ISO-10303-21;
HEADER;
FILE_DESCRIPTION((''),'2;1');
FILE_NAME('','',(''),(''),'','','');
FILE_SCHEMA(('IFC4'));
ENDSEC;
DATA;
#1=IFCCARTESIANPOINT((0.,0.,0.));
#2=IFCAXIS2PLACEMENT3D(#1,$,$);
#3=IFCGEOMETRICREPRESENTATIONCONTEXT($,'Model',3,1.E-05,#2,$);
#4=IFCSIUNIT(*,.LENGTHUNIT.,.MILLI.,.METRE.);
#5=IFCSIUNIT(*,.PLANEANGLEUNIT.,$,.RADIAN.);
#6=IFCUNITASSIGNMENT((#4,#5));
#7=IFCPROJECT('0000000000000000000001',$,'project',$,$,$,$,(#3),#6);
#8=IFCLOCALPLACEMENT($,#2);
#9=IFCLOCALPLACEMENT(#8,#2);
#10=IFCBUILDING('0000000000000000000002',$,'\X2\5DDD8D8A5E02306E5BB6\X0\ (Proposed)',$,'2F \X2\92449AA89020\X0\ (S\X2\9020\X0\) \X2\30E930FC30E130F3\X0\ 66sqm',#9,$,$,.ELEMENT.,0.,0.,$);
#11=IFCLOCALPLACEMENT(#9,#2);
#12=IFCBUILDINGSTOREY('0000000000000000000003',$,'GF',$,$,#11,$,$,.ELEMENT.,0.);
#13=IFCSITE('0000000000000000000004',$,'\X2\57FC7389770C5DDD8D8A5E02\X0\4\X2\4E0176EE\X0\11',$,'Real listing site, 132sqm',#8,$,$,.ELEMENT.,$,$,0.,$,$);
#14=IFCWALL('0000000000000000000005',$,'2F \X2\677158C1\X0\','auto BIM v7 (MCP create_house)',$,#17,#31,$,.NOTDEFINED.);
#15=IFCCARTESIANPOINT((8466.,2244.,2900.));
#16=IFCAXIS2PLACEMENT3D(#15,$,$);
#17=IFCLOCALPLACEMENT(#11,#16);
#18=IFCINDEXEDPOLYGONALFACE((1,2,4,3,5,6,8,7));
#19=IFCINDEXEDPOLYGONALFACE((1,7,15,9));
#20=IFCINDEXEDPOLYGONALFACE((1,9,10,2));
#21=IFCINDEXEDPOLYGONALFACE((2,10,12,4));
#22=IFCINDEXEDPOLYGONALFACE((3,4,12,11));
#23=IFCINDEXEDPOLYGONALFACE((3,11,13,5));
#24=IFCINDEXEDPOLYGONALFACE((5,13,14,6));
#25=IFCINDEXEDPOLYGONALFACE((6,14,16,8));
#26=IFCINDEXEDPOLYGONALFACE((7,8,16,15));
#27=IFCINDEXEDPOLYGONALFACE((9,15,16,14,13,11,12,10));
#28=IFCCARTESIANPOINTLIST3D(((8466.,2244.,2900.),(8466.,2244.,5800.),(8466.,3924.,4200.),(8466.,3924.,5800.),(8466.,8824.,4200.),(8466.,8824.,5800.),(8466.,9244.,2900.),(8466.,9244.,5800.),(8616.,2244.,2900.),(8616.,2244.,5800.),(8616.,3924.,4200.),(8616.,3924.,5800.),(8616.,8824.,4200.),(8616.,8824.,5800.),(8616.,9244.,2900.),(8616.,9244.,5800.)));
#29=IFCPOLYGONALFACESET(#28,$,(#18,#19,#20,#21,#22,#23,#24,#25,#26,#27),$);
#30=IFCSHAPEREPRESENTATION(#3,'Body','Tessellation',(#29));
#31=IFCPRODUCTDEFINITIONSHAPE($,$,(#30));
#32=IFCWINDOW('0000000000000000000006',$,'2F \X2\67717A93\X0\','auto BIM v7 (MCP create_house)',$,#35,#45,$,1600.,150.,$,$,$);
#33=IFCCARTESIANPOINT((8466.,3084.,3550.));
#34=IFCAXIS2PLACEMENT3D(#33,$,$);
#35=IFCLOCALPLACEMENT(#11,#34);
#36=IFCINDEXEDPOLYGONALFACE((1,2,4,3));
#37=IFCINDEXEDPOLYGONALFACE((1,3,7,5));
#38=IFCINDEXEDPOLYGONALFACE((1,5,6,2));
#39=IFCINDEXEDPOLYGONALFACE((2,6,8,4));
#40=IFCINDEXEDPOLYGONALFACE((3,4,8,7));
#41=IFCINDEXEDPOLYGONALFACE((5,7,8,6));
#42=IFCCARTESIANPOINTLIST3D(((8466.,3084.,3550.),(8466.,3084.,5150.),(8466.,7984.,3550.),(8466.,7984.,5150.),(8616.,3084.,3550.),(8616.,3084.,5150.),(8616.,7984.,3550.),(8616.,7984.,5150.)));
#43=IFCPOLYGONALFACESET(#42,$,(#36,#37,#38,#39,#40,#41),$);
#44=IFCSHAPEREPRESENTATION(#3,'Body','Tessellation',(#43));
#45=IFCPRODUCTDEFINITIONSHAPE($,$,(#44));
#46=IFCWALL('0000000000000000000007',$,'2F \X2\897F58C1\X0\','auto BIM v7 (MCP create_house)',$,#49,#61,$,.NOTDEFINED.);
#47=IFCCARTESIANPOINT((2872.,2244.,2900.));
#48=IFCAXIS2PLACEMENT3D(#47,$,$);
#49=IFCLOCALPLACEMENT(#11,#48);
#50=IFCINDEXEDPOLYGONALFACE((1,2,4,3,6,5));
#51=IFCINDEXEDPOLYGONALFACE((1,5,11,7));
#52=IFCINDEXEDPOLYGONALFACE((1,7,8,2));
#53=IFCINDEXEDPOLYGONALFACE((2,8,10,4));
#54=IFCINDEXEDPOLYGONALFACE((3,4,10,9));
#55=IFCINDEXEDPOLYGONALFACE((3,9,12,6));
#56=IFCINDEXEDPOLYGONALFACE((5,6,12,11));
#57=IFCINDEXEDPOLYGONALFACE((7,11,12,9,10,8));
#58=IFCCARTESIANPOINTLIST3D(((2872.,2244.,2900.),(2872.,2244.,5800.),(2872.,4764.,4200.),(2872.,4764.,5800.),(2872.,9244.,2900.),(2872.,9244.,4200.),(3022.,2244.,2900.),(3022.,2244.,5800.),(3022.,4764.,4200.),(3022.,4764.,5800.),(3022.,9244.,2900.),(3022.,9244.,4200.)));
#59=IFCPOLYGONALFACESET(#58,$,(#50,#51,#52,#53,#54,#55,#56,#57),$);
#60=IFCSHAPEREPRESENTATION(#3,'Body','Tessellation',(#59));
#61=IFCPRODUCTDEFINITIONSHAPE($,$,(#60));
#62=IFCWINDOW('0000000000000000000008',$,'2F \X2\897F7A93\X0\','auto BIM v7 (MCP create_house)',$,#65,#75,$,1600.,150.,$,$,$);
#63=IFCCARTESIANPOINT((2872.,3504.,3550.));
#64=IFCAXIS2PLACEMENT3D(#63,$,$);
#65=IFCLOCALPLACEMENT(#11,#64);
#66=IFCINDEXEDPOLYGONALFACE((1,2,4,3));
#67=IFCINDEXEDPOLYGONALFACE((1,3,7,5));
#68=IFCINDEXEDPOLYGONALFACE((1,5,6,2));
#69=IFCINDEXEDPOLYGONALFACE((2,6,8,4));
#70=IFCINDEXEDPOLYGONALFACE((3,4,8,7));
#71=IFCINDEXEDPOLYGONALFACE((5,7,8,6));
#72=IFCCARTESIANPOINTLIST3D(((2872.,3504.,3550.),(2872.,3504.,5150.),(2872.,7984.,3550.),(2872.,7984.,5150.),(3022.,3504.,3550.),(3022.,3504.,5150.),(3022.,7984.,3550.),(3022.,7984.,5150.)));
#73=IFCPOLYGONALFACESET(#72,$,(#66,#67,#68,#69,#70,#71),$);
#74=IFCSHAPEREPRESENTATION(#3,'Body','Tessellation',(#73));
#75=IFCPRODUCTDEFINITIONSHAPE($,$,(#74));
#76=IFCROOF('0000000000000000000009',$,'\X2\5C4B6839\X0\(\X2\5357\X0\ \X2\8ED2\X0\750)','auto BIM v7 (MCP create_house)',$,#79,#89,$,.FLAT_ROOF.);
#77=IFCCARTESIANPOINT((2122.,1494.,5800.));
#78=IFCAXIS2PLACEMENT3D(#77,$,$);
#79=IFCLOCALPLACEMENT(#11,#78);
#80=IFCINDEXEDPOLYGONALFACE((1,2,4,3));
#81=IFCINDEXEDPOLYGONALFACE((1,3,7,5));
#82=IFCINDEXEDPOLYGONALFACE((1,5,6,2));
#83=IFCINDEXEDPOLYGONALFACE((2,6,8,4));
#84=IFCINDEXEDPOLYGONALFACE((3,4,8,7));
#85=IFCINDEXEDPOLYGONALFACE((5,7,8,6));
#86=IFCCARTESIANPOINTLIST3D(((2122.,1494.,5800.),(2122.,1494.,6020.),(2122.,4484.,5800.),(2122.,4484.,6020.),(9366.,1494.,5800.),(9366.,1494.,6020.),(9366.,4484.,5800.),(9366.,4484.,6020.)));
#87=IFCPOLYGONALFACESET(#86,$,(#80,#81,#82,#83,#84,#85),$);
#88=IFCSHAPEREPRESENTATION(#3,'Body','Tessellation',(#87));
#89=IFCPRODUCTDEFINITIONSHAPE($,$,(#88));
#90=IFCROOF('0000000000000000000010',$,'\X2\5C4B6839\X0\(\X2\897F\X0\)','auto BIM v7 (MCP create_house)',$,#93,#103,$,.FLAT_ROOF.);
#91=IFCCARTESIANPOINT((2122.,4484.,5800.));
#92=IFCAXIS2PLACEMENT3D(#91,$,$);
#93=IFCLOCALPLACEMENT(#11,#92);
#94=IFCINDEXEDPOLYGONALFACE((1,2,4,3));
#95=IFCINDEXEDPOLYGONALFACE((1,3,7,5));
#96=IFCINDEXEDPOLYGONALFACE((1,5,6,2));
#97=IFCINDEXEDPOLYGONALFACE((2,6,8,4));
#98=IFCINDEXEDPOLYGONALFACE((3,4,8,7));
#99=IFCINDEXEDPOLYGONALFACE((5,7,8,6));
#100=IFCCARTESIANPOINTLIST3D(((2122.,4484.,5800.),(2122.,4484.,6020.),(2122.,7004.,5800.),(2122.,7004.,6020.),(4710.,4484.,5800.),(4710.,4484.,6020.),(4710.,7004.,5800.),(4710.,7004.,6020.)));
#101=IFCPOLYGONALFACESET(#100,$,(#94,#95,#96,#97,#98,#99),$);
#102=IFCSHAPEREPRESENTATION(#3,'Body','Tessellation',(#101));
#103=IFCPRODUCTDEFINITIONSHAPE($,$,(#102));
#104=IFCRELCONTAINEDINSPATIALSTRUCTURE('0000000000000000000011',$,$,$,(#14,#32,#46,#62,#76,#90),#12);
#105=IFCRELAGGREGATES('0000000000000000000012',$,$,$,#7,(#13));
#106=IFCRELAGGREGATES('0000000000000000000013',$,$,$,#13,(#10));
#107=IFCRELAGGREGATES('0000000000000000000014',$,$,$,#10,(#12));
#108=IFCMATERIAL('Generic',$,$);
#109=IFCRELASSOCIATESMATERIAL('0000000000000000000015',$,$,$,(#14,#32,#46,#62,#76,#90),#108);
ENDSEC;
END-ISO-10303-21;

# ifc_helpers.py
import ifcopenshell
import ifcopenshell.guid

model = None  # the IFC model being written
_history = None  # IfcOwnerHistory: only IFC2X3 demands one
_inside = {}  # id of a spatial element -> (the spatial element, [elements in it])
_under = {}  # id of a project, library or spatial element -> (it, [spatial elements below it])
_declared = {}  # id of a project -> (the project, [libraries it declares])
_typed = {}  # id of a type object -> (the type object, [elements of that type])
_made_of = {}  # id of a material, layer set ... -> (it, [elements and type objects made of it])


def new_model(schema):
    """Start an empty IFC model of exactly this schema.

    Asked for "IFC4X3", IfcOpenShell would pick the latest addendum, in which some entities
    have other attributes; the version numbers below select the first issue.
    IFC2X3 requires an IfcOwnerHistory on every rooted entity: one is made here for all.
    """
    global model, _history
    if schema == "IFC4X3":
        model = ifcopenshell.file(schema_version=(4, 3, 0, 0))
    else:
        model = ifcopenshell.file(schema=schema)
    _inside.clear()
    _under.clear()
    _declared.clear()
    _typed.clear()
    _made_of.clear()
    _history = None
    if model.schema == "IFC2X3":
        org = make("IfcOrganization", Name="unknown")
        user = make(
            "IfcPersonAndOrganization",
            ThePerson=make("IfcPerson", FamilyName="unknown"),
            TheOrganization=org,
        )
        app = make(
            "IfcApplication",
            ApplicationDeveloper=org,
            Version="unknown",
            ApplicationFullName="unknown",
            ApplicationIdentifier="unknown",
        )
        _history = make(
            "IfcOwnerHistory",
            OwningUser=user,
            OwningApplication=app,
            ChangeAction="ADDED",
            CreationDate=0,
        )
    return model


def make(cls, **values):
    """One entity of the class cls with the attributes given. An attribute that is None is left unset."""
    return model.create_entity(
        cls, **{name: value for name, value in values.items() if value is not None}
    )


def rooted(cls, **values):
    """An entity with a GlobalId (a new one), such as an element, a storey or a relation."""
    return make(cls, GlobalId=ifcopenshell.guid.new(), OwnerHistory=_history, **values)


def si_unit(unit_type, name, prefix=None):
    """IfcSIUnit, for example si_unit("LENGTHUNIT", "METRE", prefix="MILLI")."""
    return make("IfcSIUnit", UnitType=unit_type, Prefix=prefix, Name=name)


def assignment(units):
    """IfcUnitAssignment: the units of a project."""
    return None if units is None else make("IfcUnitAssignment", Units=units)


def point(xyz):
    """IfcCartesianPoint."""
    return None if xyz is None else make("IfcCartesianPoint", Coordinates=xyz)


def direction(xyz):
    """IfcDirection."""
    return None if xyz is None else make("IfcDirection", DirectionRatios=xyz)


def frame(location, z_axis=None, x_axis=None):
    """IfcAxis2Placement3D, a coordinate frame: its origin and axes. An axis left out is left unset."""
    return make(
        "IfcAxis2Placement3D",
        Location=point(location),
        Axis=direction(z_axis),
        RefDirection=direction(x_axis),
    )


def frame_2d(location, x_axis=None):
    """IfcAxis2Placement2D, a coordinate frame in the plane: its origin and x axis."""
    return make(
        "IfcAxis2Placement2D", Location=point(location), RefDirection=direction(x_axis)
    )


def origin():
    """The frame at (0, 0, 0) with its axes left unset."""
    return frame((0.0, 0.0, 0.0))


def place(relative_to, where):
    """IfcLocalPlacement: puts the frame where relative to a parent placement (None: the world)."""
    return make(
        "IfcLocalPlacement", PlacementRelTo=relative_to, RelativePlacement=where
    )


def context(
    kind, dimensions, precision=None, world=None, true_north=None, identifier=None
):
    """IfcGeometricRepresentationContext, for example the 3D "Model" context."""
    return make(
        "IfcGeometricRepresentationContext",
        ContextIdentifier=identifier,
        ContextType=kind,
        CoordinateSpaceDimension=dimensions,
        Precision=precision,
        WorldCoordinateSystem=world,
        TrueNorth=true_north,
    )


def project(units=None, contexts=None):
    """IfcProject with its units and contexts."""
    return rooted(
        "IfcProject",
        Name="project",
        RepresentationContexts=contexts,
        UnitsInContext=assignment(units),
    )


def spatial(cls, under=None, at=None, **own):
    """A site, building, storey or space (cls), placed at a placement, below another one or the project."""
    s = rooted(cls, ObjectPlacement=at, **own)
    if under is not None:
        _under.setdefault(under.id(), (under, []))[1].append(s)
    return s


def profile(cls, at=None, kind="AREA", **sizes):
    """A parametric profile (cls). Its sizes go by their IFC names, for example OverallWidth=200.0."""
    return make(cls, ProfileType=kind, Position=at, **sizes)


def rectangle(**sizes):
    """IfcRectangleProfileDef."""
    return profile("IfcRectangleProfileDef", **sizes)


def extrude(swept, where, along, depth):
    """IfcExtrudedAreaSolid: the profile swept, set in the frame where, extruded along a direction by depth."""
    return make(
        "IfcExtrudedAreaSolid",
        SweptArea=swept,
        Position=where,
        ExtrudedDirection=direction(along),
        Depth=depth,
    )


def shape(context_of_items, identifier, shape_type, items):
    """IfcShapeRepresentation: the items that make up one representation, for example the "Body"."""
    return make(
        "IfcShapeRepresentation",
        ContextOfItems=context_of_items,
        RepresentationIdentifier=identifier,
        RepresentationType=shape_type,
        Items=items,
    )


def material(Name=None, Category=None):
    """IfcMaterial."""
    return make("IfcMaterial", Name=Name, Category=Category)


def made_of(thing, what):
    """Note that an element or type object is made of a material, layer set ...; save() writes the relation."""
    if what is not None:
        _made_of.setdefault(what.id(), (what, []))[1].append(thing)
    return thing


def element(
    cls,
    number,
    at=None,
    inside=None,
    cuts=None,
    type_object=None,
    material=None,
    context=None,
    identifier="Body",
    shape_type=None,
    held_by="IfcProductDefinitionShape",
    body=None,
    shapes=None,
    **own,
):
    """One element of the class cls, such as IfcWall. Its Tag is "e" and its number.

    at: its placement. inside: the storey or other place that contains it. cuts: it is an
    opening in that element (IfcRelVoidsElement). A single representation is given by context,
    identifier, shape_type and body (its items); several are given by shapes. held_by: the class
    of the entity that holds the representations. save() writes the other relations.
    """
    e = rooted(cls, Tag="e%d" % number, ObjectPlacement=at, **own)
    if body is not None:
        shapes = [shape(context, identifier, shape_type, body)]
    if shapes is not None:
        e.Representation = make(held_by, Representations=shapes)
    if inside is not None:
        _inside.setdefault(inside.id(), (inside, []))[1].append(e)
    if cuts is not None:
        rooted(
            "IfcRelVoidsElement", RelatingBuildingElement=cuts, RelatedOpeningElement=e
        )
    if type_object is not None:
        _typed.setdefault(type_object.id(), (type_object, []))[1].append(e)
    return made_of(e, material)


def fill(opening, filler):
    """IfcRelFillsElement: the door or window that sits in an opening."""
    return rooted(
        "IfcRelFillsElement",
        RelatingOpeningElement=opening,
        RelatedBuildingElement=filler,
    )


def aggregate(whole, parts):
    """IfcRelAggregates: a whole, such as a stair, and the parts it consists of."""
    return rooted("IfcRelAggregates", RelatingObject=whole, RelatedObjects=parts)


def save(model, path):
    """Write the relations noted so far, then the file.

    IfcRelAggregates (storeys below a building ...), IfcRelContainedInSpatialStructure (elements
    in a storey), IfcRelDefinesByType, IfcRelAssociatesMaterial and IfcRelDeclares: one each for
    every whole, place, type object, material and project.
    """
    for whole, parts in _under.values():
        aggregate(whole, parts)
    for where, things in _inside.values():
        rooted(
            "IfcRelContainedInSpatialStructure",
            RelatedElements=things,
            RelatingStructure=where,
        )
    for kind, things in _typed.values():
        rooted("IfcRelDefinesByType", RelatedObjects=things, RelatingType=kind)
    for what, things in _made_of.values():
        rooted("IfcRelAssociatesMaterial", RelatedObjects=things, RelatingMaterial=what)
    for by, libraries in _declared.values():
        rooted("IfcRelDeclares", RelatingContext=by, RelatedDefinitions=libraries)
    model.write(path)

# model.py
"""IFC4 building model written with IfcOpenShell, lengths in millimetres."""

from ifc_helpers import new_model, si_unit, frame, frame_2d, origin, place, context, project, spatial, rectangle, extrude, material, element, fill, save


model = new_model("IFC4")

# Units and contexts
model_context = context("Model", 3, precision=1e-05, world=origin())
ifc_project = project(units=[si_unit("LENGTHUNIT", "METRE", prefix="MILLI"), si_unit("PLANEANGLEUNIT", "RADIAN")], contexts=[model_context])

# Site, building, storey
site_placement = place(None, origin())
site = spatial("IfcSite", under=ifc_project, at=site_placement, Name="埼玉県川越市4丁目11", ObjectType="Real listing site, 132sqm", CompositionType="ELEMENT", RefElevation=0.0)
building_placement = place(site_placement, origin())
building = spatial("IfcBuilding", under=site, at=building_placement, Name="川越市の家 (Proposed)", ObjectType="2F 鉄骨造 (S造) ラーメン 66sqm", CompositionType="ELEMENT", ElevationOfRefHeight=0.0, ElevationOfTerrain=0.0)
storey_placement = place(building_placement, origin())
storey = spatial("IfcBuildingStorey", under=building, at=storey_placement, Name="GF", CompositionType="ELEMENT", Elevation=0.0)

# Shared definitions
ifc_material = material(Name="Generic")

# Walls, openings, windows
wall_1_placement = place(storey_placement, frame((8466.0, 2244.0, 2900.0)))
wall_1 = element("IfcWall", 1, at=wall_1_placement, inside=storey, material=ifc_material, Name="2F 東壁", Description="auto BIM v7 (MCP create_house)", PredefinedType="NOTDEFINED", context=model_context, shape_type="SweptSolid", body=[
    extrude(rectangle(XDim=150.0, YDim=7000.0, at=frame_2d((75.0, 3500.0))), frame((8466.0, 2244.0, 2900.0)), (0.0, 0.0, 1.0), 2900.0),
])
opening_1_placement = place(storey_placement, frame((8466.0, 3084.0, 3550.0)))
opening_1 = element("IfcOpeningElement", 2, at=opening_1_placement, cuts=wall_1, PredefinedType="NOTDEFINED", context=model_context, shape_type="SweptSolid", body=[
    extrude(rectangle(XDim=150.0, YDim=4900.0, at=frame_2d((75.0, 2450.0))), frame((8466.0, 3084.0, 3550.0)), (0.0, 0.0, 1.0), 1600.0),
])
window_1_placement = place(storey_placement, frame((8466.0, 3084.0, 3550.0)))
window_1 = element("IfcWindow", 3, at=window_1_placement, inside=storey, material=ifc_material, Name="2F 東窓", Description="auto BIM v7 (MCP create_house)", OverallHeight=1600.0, OverallWidth=150.0, context=model_context, shape_type="SweptSolid", body=[
    extrude(rectangle(XDim=150.0, YDim=4900.0, at=frame_2d((75.0, 2450.0))), frame((8466.0, 3084.0, 3550.0)), (0.0, 0.0, 1.0), 1600.0),
])
fill(opening_1, window_1)
wall_2_placement = place(storey_placement, frame((2872.0, 2244.0, 2900.0)))
wall_2 = element("IfcWall", 4, at=wall_2_placement, inside=storey, material=ifc_material, Name="2F 西壁", Description="auto BIM v7 (MCP create_house)", PredefinedType="NOTDEFINED", context=model_context, shape_type="SweptSolid", body=[
    extrude(rectangle(XDim=150.0, YDim=7000.0, at=frame_2d((75.0, 3500.0))), frame((2872.0, 2244.0, 2900.0)), (0.0, 0.0, 1.0), 2900.0),
])
opening_2_placement = place(storey_placement, frame((2872.0, 3504.0, 3550.0)))
opening_2 = element("IfcOpeningElement", 5, at=opening_2_placement, cuts=wall_2, PredefinedType="NOTDEFINED", context=model_context, shape_type="SweptSolid", body=[
    extrude(rectangle(XDim=150.0, YDim=4480.0, at=frame_2d((75.0, 2240.0))), frame((2872.0, 3504.0, 3550.0)), (0.0, 0.0, 1.0), 1600.0),
])
window_2_placement = place(storey_placement, frame((2872.0, 3504.0, 3550.0)))
window_2 = element("IfcWindow", 6, at=window_2_placement, inside=storey, material=ifc_material, Name="2F 西窓", Description="auto BIM v7 (MCP create_house)", OverallHeight=1600.0, OverallWidth=150.0, context=model_context, shape_type="SweptSolid", body=[
    extrude(rectangle(XDim=150.0, YDim=4480.0, at=frame_2d((75.0, 2240.0))), frame((2872.0, 3504.0, 3550.0)), (0.0, 0.0, 1.0), 1600.0),
])
fill(opening_2, window_2)

# Roofs
roof_1_placement = place(storey_placement, frame((2122.0, 1494.0, 5800.0)))
element("IfcRoof", 7, at=roof_1_placement, inside=storey, material=ifc_material, Name="屋根(南 軒750)", Description="auto BIM v7 (MCP create_house)", PredefinedType="FLAT_ROOF", context=model_context, shape_type="SweptSolid", body=[
    extrude(rectangle(XDim=7244.0, YDim=2990.0, at=frame_2d((3622.0, 1495.0))), frame((2122.0, 1494.0, 5800.0)), (0.0, 0.0, 1.0), 220.0),
])
roof_2_placement = place(storey_placement, frame((2122.0, 4484.0, 5800.0)))
element("IfcRoof", 8, at=roof_2_placement, inside=storey, material=ifc_material, Name="屋根(西)", Description="auto BIM v7 (MCP create_house)", PredefinedType="FLAT_ROOF", context=model_context, shape_type="SweptSolid", body=[
    extrude(rectangle(XDim=2588.0, YDim=2520.0, at=frame_2d((1294.0, 1260.0))), frame((2122.0, 4484.0, 5800.0)), (0.0, 0.0, 1.0), 220.0),
])

save(model, "model.ifc")
